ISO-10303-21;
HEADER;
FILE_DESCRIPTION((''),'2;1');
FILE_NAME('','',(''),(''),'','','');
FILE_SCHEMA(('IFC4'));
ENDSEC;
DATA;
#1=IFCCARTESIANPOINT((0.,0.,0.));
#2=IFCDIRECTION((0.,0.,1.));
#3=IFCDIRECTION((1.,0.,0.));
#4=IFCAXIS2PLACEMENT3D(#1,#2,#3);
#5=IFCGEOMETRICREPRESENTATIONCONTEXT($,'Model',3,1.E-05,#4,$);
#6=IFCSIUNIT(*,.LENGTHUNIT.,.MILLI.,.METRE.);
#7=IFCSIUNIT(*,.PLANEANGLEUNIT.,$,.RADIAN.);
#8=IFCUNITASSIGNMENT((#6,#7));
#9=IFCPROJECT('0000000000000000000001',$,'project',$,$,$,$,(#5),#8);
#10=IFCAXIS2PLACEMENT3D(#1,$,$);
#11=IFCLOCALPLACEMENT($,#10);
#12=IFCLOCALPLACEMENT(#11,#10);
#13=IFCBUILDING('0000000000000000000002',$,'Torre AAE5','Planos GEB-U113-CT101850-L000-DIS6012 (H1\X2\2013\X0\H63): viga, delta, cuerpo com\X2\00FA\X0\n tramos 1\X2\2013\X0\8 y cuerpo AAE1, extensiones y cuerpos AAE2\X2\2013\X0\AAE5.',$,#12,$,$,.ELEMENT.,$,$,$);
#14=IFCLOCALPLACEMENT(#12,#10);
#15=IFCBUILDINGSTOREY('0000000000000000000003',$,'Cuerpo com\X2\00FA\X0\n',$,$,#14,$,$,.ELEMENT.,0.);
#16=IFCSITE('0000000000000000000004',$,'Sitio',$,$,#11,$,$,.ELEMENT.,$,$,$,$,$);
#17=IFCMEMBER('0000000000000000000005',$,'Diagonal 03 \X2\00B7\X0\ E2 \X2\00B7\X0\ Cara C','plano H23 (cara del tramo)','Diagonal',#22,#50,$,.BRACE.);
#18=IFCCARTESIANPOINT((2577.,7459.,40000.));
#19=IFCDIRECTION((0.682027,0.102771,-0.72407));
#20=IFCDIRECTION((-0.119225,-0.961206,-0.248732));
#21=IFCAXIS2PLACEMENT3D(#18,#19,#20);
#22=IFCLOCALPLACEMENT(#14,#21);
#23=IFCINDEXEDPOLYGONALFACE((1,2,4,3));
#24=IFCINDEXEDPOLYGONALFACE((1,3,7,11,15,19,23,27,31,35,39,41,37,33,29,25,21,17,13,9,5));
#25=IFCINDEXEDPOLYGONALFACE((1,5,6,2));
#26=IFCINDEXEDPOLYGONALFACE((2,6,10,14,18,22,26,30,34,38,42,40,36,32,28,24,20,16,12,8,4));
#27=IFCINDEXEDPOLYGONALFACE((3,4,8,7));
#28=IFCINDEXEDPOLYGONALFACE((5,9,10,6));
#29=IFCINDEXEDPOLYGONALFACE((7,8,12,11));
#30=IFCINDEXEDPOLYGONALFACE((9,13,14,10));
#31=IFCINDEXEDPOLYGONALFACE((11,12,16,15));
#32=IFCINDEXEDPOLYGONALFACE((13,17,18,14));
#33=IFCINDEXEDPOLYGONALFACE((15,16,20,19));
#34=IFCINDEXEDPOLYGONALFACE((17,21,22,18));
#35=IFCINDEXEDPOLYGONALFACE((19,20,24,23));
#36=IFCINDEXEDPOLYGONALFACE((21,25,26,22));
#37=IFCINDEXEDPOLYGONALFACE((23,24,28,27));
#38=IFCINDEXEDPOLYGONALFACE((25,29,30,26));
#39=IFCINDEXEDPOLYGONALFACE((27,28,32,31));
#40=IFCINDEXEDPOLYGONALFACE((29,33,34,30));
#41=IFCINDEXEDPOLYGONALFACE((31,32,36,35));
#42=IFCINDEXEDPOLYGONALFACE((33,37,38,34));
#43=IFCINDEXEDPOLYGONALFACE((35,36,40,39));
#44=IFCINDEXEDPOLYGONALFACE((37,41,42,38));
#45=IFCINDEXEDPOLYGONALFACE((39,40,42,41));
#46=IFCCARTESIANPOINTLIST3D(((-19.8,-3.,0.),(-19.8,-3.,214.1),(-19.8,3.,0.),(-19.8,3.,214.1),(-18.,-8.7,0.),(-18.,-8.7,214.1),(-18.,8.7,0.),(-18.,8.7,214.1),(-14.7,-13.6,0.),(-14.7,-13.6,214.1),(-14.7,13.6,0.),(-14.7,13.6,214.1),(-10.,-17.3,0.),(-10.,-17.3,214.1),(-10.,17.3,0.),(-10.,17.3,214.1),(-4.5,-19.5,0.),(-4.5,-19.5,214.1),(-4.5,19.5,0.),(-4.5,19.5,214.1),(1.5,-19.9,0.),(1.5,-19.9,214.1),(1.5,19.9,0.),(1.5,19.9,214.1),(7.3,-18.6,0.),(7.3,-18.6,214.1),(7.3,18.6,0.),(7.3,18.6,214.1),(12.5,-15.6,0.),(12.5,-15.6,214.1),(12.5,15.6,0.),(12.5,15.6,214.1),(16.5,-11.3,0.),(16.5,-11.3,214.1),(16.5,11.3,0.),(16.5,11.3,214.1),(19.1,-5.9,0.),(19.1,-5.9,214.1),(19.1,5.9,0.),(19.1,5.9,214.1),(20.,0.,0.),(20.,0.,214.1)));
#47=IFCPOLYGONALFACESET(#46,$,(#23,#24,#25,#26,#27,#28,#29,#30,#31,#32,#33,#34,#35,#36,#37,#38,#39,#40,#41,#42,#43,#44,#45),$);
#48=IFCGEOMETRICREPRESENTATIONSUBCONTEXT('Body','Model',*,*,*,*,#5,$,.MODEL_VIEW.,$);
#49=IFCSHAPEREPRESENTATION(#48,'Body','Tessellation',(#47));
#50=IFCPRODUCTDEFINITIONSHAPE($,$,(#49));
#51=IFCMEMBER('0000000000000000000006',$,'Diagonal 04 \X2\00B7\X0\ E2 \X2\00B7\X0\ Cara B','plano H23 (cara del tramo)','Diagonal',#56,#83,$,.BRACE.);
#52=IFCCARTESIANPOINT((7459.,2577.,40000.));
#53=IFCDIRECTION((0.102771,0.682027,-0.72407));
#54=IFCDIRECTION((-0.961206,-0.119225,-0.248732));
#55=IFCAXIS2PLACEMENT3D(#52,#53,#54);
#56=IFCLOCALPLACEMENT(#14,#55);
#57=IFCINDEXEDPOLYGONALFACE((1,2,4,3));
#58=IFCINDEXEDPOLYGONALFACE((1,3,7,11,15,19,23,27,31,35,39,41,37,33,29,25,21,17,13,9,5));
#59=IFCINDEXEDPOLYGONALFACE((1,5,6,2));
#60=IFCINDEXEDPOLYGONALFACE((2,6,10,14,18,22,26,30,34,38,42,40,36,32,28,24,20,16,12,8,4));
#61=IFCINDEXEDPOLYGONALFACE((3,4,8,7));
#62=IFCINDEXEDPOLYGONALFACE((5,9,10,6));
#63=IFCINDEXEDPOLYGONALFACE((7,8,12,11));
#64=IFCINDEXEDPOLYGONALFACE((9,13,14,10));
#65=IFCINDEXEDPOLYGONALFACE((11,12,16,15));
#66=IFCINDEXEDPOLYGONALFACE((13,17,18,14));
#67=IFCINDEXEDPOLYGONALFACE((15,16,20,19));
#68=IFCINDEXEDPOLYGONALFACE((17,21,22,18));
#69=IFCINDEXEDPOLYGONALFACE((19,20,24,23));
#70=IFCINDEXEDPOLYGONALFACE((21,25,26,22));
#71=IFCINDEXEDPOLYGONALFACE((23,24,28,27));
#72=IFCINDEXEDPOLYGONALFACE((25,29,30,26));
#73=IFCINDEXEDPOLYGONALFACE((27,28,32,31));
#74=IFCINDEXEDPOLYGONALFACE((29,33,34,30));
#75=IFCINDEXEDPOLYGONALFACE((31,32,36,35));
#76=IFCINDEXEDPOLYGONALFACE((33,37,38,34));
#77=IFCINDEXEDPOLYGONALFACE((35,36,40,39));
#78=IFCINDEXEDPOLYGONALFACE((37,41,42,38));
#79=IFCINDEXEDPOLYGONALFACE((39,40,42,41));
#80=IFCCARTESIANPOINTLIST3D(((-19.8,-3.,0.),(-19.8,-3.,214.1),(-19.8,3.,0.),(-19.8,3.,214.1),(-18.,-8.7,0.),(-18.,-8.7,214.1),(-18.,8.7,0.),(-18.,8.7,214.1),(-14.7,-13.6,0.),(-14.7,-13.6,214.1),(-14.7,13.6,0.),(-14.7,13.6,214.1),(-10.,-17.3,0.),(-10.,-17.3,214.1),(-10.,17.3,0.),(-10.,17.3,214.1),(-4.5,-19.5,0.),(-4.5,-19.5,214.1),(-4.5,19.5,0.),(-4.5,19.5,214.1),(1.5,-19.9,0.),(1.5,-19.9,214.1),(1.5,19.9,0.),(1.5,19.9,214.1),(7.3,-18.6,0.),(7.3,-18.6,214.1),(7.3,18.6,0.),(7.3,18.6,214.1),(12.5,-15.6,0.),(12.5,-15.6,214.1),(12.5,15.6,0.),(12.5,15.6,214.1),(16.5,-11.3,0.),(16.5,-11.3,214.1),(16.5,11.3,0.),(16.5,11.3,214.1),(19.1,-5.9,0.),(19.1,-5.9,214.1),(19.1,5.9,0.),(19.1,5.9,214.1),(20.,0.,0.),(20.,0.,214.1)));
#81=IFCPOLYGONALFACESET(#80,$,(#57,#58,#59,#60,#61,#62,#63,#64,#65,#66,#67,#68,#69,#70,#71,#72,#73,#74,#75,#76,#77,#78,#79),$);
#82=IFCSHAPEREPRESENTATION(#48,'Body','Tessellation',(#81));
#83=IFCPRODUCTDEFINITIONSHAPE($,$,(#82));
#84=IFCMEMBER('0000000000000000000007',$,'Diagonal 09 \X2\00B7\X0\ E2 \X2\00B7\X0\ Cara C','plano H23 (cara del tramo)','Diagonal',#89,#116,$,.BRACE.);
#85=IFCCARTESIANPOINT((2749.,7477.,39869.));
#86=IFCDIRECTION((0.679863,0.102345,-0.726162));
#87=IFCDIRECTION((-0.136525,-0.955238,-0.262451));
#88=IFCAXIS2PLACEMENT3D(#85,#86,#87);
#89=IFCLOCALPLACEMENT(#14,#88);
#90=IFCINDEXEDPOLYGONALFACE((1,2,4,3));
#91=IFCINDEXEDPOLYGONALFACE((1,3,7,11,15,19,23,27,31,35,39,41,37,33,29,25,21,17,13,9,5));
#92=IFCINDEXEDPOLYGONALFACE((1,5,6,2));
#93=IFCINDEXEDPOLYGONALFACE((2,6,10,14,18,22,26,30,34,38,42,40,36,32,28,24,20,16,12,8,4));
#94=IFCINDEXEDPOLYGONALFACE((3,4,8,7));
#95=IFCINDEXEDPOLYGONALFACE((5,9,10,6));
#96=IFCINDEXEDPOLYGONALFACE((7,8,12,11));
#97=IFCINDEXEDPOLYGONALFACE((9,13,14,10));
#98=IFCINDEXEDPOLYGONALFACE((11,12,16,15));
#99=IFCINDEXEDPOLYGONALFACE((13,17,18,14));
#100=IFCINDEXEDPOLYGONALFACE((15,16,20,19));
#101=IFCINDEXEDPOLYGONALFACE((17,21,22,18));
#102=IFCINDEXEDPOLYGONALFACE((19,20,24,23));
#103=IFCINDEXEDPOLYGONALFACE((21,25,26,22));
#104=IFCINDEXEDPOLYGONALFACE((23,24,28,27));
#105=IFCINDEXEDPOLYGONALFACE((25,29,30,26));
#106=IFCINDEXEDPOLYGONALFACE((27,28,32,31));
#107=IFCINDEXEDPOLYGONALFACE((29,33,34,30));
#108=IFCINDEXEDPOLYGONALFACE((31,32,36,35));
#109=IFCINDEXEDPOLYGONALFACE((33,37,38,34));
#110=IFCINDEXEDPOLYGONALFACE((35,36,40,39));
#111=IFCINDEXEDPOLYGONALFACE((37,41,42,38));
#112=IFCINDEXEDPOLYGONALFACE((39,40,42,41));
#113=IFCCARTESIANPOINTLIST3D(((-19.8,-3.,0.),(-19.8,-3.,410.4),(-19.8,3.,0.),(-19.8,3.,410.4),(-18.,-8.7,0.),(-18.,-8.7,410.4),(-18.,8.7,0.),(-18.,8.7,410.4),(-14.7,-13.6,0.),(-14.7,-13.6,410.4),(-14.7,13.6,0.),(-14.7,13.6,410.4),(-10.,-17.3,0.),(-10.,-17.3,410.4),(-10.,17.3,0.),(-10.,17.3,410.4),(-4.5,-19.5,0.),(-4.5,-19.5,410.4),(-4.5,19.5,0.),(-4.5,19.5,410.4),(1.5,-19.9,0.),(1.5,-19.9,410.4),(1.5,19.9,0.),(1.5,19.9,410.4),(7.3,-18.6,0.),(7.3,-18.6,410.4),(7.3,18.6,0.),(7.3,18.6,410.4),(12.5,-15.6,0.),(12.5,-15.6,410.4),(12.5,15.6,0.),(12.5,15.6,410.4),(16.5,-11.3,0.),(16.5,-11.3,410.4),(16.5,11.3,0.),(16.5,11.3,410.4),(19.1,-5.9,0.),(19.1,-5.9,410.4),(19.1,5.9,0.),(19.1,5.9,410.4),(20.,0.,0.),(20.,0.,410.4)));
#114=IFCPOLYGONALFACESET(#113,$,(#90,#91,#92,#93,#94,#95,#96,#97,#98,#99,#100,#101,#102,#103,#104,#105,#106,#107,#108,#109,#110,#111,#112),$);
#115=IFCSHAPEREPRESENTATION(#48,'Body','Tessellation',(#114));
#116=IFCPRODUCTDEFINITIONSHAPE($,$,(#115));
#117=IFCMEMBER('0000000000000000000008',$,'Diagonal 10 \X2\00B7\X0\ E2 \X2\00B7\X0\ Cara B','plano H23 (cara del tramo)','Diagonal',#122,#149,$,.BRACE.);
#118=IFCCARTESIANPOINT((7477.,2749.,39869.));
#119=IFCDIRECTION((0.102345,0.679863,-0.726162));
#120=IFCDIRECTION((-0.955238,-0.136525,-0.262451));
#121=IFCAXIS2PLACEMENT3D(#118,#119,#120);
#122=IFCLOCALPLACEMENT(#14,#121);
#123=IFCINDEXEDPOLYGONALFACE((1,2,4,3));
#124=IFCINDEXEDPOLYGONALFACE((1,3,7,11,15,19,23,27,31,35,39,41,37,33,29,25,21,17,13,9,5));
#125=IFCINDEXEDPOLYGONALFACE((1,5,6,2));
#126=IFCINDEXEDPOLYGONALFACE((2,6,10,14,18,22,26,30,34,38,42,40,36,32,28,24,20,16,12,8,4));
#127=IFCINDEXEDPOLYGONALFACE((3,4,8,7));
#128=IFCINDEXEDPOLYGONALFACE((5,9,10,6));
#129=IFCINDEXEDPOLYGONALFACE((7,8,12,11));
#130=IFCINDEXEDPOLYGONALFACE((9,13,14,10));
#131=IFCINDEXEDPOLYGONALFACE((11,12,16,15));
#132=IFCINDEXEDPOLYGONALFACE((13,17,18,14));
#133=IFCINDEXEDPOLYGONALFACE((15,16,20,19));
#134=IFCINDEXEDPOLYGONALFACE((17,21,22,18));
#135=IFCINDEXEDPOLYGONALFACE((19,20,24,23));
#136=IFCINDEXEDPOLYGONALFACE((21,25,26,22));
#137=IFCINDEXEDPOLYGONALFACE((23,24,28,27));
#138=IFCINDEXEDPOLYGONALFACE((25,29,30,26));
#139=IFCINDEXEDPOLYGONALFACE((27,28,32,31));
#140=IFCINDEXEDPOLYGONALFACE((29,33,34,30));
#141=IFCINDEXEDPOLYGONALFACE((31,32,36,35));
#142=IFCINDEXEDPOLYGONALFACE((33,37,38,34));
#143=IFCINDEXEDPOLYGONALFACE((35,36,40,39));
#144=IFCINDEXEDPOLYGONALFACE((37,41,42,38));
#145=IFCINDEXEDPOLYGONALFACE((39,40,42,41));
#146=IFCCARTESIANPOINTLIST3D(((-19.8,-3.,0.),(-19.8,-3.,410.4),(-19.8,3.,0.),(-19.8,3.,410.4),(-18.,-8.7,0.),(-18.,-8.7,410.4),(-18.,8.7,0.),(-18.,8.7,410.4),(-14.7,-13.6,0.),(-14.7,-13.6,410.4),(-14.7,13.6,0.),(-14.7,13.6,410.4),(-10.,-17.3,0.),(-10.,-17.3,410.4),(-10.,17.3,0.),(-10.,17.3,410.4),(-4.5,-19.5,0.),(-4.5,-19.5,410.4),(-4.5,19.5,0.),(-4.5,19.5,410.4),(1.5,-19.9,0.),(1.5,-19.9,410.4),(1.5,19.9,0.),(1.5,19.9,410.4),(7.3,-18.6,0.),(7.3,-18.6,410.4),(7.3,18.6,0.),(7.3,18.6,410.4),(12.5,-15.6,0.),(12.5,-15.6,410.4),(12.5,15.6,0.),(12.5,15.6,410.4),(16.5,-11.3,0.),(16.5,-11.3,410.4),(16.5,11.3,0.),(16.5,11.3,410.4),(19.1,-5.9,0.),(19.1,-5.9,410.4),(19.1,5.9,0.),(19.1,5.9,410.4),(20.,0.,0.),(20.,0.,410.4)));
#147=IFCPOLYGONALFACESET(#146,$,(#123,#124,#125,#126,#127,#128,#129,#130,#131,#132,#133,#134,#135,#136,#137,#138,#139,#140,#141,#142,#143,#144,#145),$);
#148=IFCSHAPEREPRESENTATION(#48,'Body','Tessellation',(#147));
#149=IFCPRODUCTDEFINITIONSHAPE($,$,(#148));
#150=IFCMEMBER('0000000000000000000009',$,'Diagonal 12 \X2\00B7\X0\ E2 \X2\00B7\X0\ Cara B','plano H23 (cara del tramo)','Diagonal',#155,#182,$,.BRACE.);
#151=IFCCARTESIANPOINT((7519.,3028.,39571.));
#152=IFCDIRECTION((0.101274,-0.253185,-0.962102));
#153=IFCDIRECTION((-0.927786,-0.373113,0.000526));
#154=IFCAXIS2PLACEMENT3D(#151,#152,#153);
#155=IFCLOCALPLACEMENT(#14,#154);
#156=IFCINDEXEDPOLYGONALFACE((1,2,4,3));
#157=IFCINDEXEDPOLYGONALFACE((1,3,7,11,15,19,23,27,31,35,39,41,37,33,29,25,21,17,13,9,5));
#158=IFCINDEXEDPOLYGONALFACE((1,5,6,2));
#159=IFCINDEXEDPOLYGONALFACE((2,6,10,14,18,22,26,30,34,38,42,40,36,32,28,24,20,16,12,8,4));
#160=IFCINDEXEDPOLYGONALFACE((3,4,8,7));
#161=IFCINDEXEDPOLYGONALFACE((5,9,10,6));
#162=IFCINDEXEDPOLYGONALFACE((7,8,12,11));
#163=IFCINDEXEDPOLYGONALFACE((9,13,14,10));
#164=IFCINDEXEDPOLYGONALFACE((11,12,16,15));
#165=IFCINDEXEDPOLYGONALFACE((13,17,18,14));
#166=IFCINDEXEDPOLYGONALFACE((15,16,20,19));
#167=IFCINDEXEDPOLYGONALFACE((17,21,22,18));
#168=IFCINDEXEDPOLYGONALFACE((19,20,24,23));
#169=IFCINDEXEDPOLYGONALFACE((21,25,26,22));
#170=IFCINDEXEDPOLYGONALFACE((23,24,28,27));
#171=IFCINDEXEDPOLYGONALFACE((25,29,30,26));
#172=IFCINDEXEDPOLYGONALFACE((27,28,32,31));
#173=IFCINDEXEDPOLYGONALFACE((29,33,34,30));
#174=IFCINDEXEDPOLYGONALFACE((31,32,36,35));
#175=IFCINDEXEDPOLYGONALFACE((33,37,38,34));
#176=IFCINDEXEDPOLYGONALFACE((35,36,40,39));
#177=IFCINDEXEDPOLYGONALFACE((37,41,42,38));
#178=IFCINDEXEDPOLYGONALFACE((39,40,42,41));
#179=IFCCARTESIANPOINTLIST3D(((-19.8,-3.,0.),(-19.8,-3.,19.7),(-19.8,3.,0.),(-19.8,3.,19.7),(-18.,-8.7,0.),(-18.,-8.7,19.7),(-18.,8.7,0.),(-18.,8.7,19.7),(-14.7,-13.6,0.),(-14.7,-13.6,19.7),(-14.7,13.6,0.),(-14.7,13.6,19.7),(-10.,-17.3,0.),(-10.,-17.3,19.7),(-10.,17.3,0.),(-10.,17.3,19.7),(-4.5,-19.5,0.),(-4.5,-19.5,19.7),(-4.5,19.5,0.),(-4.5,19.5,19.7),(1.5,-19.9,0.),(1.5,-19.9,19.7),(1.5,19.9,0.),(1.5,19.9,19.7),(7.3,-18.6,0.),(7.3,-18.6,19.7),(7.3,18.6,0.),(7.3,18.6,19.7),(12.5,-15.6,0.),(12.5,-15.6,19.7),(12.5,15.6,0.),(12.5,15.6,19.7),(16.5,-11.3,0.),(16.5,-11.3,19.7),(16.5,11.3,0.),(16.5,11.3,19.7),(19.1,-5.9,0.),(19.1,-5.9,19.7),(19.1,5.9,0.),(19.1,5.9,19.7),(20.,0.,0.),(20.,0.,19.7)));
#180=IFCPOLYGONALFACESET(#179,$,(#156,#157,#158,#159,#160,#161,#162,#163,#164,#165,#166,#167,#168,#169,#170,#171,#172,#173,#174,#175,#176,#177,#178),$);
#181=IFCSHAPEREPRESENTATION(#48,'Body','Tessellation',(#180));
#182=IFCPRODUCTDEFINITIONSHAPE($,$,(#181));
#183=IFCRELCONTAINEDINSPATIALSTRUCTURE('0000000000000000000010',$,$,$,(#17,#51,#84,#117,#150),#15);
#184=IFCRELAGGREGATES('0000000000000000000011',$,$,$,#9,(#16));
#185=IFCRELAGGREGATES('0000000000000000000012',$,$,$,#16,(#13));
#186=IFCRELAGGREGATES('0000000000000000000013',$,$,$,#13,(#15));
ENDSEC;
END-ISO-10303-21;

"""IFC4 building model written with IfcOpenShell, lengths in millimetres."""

from ifc_helpers import new_model, si_unit, frame, origin, origin_with_axes, place, context, subcontext, project, spatial, circle, extrude, element, save


model = new_model("IFC4")

# Units and contexts
model_context = context("Model", 3, precision=1e-05, world=origin_with_axes())
body_context = subcontext(model_context, "Body", "Model", "MODEL_VIEW")
ifc_project = project(units=[si_unit("LENGTHUNIT", "METRE", prefix="MILLI"), si_unit("PLANEANGLEUNIT", "RADIAN")], contexts=[model_context])

# Site, building, storey
site_placement = place(None, origin())
site = spatial("IfcSite", under=ifc_project, at=site_placement, Name="Sitio", CompositionType="ELEMENT")
building_placement = place(site_placement, origin())
building = spatial("IfcBuilding", under=site, at=building_placement, Name="Torre AAE5", Description="Planos GEB-U113-CT101850-L000-DIS6012 (H1–H63): viga, delta, cuerpo común tramos 1–8 y cuerpo AAE1, extensiones y cuerpos AAE2–AAE5.", CompositionType="ELEMENT")
storey_placement = place(building_placement, origin())
storey = spatial("IfcBuildingStorey", under=building, at=storey_placement, Name="Cuerpo común", CompositionType="ELEMENT", Elevation=0.0)

# Members
for number, where, z_axis, x_axis, name in (
    (1, (2577.0, 7459.0, 40000.0), (0.682027, 0.102771, -0.72407), (-0.119225, -0.961206, -0.248732), "Diagonal 03 · E2 · Cara C"),
    (2, (7459.0, 2577.0, 40000.0), (0.102771, 0.682027, -0.72407), (-0.961206, -0.119225, -0.248732), "Diagonal 04 · E2 · Cara B"),
):
    element("IfcMember", number, at=place(storey_placement, frame(where, z_axis=z_axis, x_axis=x_axis)), inside=storey, Name=name, Description="plano H23 (cara del tramo)", ObjectType="Diagonal", PredefinedType="BRACE", context=body_context, shape_type="SweptSolid", body=[
        extrude(circle(Radius=20.0), None, (0.0, 0.0, 1.0), 214.1),
    ])
for number, where, z_axis, x_axis, name in (
    (3, (2749.0, 7477.0, 39869.0), (0.679863, 0.102345, -0.726162), (-0.136525, -0.955238, -0.262451), "Diagonal 09 · E2 · Cara C"),
    (4, (7477.0, 2749.0, 39869.0), (0.102345, 0.679863, -0.726162), (-0.955238, -0.136525, -0.262451), "Diagonal 10 · E2 · Cara B"),
):
    element("IfcMember", number, at=place(storey_placement, frame(where, z_axis=z_axis, x_axis=x_axis)), inside=storey, Name=name, Description="plano H23 (cara del tramo)", ObjectType="Diagonal", PredefinedType="BRACE", context=body_context, shape_type="SweptSolid", body=[
        extrude(circle(Radius=20.0), None, (0.0, 0.0, 1.0), 410.4),
    ])
member_1_placement = place(storey_placement, frame((7519.0, 3028.0, 39571.0), z_axis=(0.101274, -0.253185, -0.962102), x_axis=(-0.927786, -0.373113, 0.000526)))
element("IfcMember", 5, at=member_1_placement, inside=storey, Name="Diagonal 12 · E2 · Cara B", Description="plano H23 (cara del tramo)", ObjectType="Diagonal", PredefinedType="BRACE", context=body_context, shape_type="SweptSolid", body=[
    extrude(circle(Radius=20.0), None, (0.0, 0.0, 1.0), 19.7),
])

save(model, "model.ifc")
